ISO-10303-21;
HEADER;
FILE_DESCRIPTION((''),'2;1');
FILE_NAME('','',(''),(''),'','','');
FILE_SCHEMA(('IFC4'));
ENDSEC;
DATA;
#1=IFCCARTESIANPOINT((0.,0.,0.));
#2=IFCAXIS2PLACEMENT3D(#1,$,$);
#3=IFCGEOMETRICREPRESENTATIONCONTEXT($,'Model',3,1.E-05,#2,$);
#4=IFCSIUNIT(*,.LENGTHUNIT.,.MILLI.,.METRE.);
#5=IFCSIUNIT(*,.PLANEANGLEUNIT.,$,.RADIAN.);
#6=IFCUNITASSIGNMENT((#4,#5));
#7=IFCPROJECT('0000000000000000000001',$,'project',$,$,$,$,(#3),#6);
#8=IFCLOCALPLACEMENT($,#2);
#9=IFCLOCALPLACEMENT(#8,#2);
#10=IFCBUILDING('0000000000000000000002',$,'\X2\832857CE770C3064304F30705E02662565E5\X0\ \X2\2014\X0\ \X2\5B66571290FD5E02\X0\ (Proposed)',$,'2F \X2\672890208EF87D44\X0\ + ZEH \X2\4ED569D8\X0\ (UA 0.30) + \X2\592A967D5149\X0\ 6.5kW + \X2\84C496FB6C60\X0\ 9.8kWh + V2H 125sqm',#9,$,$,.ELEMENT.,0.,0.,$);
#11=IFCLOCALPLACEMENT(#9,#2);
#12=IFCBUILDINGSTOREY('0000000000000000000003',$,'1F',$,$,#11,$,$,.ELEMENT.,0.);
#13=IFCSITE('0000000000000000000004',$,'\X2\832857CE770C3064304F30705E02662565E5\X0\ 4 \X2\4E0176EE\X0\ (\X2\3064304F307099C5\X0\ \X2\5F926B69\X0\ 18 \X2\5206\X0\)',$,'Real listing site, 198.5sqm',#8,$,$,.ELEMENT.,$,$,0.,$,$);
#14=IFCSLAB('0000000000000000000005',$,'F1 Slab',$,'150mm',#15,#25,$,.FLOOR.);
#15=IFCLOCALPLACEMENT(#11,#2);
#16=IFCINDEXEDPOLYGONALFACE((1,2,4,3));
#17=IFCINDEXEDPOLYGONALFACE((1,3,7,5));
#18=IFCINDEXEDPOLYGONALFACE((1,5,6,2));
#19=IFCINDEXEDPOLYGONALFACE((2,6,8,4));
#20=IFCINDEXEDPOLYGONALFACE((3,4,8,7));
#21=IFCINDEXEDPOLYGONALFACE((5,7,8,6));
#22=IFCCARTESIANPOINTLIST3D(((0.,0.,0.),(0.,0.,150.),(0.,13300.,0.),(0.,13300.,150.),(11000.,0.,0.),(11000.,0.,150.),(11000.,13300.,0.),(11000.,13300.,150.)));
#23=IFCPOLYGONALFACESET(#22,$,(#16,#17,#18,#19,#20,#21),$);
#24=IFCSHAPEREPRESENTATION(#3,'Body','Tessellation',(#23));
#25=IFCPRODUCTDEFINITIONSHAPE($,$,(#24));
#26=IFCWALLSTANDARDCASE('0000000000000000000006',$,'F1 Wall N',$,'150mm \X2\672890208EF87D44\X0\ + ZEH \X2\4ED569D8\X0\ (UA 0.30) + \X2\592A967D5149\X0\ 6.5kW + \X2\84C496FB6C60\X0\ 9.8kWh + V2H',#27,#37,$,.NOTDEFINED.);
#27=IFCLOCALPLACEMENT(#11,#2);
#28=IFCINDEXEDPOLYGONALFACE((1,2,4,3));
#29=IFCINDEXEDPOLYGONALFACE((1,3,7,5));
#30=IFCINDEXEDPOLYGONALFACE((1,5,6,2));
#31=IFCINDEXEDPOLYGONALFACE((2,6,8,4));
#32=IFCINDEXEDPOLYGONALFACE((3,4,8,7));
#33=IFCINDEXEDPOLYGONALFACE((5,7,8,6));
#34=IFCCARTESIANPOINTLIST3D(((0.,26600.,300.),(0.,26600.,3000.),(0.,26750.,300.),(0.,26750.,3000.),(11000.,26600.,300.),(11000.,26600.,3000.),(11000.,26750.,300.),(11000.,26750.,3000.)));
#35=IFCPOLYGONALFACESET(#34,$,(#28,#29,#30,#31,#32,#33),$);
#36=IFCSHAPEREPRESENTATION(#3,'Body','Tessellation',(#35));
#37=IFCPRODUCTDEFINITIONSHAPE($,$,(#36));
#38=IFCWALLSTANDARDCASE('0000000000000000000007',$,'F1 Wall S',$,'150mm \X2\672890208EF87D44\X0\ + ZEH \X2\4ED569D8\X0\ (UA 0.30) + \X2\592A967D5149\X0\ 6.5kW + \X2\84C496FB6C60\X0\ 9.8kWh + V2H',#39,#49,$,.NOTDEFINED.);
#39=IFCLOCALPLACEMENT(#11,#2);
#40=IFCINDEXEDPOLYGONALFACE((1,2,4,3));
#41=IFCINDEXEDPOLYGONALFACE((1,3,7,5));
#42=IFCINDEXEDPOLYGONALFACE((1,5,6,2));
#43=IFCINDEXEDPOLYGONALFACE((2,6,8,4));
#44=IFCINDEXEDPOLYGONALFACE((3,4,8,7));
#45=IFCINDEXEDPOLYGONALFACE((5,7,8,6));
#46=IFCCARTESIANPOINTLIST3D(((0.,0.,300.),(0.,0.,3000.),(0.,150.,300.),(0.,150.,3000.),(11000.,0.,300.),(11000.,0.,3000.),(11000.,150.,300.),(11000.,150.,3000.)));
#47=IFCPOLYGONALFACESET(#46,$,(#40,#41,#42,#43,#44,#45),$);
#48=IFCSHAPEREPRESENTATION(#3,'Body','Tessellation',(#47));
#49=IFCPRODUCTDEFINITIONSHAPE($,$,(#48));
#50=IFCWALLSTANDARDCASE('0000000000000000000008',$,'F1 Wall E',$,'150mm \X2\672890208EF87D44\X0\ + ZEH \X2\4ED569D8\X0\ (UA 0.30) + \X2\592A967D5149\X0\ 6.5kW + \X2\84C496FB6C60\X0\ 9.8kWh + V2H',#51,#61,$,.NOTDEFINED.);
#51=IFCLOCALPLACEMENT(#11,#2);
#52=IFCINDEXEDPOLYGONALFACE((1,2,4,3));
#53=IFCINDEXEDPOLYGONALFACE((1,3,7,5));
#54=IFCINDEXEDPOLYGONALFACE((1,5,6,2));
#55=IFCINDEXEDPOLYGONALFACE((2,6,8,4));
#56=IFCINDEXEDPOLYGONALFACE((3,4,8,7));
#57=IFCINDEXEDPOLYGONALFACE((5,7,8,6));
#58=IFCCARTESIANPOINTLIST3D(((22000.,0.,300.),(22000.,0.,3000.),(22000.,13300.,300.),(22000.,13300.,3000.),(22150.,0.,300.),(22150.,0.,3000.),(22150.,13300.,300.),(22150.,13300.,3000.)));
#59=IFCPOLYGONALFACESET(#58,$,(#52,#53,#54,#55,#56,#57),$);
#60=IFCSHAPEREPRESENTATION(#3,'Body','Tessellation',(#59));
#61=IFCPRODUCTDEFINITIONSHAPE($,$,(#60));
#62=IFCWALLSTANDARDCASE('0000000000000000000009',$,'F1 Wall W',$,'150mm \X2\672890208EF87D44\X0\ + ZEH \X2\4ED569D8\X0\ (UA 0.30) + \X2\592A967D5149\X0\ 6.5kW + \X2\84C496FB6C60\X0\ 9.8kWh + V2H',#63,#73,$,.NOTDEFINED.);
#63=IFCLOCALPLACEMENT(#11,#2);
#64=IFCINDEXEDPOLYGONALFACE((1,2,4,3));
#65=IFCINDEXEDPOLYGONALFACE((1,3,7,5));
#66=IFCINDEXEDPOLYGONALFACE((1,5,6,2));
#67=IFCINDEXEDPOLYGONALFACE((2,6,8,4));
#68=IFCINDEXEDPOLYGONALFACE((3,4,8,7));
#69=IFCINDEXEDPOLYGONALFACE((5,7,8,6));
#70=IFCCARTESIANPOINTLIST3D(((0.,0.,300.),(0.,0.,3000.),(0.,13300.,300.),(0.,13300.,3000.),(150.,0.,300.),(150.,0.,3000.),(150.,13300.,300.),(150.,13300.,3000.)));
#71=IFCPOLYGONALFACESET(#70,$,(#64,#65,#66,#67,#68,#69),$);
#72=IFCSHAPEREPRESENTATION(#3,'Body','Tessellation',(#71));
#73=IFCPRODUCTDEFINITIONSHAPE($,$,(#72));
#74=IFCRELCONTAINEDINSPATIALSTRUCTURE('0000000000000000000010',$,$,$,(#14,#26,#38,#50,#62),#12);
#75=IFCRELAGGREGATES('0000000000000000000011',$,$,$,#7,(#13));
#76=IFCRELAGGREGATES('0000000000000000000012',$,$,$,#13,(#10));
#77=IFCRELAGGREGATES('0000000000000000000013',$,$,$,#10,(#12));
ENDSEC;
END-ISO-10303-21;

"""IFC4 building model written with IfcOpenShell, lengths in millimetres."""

from ifc_helpers import new_model, si_unit, frame, frame_2d, origin, place, context, project, spatial, rectangle, extrude, element, save


model = new_model("IFC4")

# Units and contexts
model_context = context("Model", 3, precision=1e-05, world=origin())
ifc_project = project(units=[si_unit("LENGTHUNIT", "METRE", prefix="MILLI"), si_unit("PLANEANGLEUNIT", "RADIAN")], contexts=[model_context])

# Site, building, storey
site_placement = place(None, origin())
site = spatial("IfcSite", under=ifc_project, at=site_placement, Name="茨城県つくば市春日 4 丁目 (つくば駅 徒歩 18 分)", ObjectType="Real listing site, 198.5sqm", CompositionType="ELEMENT", RefElevation=0.0)
building_placement = place(site_placement, origin())
building = spatial("IfcBuilding", under=site, at=building_placement, Name="茨城県つくば市春日 — 学園都市 (Proposed)", ObjectType="2F 木造軸組 + ZEH 仕様 (UA 0.30) + 太陽光 6.5kW + 蓄電池 9.8kWh + V2H 125sqm", CompositionType="ELEMENT", ElevationOfRefHeight=0.0, ElevationOfTerrain=0.0)
storey_placement = place(building_placement, origin())
storey = spatial("IfcBuildingStorey", under=building, at=storey_placement, Name="1F", CompositionType="ELEMENT", Elevation=0.0)

# Slab
slab_placement = place(storey_placement, origin())
element("IfcSlab", 1, at=slab_placement, inside=storey, Name="F1 Slab", ObjectType="150mm", PredefinedType="FLOOR", context=model_context, shape_type="SweptSolid", body=[
    extrude(rectangle(XDim=11000.0, YDim=13300.0, at=frame_2d((5500.0, 6650.0))), origin(), (0.0, 0.0, 1.0), 150.0),
])

# Walls
wall_1_placement = place(storey_placement, frame((0.0, 13300.0, 150.0)))
element("IfcWallStandardCase", 2, at=wall_1_placement, inside=storey, Name="F1 Wall N", ObjectType="150mm 木造軸組 + ZEH 仕様 (UA 0.30) + 太陽光 6.5kW + 蓄電池 9.8kWh + V2H", PredefinedType="NOTDEFINED", context=model_context, shape_type="SweptSolid", body=[
    extrude(rectangle(XDim=11000.0, YDim=150.0, at=frame_2d((5500.0, 75.0))), frame((0.0, 13300.0, 150.0)), (0.0, 0.0, 1.0), 2700.0),
])
wall_2_placement = place(storey_placement, frame((0.0, 0.0, 150.0)))
element("IfcWallStandardCase", 3, at=wall_2_placement, inside=storey, Name="F1 Wall S", ObjectType="150mm 木造軸組 + ZEH 仕様 (UA 0.30) + 太陽光 6.5kW + 蓄電池 9.8kWh + V2H", PredefinedType="NOTDEFINED", context=model_context, shape_type="SweptSolid", body=[
    extrude(rectangle(XDim=11000.0, YDim=150.0, at=frame_2d((5500.0, 75.0))), frame((0.0, 0.0, 150.0)), (0.0, 0.0, 1.0), 2700.0),
])
wall_3_placement = place(storey_placement, frame((11000.0, 0.0, 150.0)))
element("IfcWallStandardCase", 4, at=wall_3_placement, inside=storey, Name="F1 Wall E", ObjectType="150mm 木造軸組 + ZEH 仕様 (UA 0.30) + 太陽光 6.5kW + 蓄電池 9.8kWh + V2H", PredefinedType="NOTDEFINED", context=model_context, shape_type="SweptSolid", body=[
    extrude(rectangle(XDim=150.0, YDim=13300.0, at=frame_2d((75.0, 6650.0))), frame((11000.0, 0.0, 150.0)), (0.0, 0.0, 1.0), 2700.0),
])
wall_4_placement = place(storey_placement, frame((0.0, 0.0, 150.0)))
element("IfcWallStandardCase", 5, at=wall_4_placement, inside=storey, Name="F1 Wall W", ObjectType="150mm 木造軸組 + ZEH 仕様 (UA 0.30) + 太陽光 6.5kW + 蓄電池 9.8kWh + V2H", PredefinedType="NOTDEFINED", context=model_context, shape_type="SweptSolid", body=[
    extrude(rectangle(XDim=150.0, YDim=13300.0, at=frame_2d((75.0, 6650.0))), frame((0.0, 0.0, 150.0)), (0.0, 0.0, 1.0), 2700.0),
])

save(model, "model.ifc")
